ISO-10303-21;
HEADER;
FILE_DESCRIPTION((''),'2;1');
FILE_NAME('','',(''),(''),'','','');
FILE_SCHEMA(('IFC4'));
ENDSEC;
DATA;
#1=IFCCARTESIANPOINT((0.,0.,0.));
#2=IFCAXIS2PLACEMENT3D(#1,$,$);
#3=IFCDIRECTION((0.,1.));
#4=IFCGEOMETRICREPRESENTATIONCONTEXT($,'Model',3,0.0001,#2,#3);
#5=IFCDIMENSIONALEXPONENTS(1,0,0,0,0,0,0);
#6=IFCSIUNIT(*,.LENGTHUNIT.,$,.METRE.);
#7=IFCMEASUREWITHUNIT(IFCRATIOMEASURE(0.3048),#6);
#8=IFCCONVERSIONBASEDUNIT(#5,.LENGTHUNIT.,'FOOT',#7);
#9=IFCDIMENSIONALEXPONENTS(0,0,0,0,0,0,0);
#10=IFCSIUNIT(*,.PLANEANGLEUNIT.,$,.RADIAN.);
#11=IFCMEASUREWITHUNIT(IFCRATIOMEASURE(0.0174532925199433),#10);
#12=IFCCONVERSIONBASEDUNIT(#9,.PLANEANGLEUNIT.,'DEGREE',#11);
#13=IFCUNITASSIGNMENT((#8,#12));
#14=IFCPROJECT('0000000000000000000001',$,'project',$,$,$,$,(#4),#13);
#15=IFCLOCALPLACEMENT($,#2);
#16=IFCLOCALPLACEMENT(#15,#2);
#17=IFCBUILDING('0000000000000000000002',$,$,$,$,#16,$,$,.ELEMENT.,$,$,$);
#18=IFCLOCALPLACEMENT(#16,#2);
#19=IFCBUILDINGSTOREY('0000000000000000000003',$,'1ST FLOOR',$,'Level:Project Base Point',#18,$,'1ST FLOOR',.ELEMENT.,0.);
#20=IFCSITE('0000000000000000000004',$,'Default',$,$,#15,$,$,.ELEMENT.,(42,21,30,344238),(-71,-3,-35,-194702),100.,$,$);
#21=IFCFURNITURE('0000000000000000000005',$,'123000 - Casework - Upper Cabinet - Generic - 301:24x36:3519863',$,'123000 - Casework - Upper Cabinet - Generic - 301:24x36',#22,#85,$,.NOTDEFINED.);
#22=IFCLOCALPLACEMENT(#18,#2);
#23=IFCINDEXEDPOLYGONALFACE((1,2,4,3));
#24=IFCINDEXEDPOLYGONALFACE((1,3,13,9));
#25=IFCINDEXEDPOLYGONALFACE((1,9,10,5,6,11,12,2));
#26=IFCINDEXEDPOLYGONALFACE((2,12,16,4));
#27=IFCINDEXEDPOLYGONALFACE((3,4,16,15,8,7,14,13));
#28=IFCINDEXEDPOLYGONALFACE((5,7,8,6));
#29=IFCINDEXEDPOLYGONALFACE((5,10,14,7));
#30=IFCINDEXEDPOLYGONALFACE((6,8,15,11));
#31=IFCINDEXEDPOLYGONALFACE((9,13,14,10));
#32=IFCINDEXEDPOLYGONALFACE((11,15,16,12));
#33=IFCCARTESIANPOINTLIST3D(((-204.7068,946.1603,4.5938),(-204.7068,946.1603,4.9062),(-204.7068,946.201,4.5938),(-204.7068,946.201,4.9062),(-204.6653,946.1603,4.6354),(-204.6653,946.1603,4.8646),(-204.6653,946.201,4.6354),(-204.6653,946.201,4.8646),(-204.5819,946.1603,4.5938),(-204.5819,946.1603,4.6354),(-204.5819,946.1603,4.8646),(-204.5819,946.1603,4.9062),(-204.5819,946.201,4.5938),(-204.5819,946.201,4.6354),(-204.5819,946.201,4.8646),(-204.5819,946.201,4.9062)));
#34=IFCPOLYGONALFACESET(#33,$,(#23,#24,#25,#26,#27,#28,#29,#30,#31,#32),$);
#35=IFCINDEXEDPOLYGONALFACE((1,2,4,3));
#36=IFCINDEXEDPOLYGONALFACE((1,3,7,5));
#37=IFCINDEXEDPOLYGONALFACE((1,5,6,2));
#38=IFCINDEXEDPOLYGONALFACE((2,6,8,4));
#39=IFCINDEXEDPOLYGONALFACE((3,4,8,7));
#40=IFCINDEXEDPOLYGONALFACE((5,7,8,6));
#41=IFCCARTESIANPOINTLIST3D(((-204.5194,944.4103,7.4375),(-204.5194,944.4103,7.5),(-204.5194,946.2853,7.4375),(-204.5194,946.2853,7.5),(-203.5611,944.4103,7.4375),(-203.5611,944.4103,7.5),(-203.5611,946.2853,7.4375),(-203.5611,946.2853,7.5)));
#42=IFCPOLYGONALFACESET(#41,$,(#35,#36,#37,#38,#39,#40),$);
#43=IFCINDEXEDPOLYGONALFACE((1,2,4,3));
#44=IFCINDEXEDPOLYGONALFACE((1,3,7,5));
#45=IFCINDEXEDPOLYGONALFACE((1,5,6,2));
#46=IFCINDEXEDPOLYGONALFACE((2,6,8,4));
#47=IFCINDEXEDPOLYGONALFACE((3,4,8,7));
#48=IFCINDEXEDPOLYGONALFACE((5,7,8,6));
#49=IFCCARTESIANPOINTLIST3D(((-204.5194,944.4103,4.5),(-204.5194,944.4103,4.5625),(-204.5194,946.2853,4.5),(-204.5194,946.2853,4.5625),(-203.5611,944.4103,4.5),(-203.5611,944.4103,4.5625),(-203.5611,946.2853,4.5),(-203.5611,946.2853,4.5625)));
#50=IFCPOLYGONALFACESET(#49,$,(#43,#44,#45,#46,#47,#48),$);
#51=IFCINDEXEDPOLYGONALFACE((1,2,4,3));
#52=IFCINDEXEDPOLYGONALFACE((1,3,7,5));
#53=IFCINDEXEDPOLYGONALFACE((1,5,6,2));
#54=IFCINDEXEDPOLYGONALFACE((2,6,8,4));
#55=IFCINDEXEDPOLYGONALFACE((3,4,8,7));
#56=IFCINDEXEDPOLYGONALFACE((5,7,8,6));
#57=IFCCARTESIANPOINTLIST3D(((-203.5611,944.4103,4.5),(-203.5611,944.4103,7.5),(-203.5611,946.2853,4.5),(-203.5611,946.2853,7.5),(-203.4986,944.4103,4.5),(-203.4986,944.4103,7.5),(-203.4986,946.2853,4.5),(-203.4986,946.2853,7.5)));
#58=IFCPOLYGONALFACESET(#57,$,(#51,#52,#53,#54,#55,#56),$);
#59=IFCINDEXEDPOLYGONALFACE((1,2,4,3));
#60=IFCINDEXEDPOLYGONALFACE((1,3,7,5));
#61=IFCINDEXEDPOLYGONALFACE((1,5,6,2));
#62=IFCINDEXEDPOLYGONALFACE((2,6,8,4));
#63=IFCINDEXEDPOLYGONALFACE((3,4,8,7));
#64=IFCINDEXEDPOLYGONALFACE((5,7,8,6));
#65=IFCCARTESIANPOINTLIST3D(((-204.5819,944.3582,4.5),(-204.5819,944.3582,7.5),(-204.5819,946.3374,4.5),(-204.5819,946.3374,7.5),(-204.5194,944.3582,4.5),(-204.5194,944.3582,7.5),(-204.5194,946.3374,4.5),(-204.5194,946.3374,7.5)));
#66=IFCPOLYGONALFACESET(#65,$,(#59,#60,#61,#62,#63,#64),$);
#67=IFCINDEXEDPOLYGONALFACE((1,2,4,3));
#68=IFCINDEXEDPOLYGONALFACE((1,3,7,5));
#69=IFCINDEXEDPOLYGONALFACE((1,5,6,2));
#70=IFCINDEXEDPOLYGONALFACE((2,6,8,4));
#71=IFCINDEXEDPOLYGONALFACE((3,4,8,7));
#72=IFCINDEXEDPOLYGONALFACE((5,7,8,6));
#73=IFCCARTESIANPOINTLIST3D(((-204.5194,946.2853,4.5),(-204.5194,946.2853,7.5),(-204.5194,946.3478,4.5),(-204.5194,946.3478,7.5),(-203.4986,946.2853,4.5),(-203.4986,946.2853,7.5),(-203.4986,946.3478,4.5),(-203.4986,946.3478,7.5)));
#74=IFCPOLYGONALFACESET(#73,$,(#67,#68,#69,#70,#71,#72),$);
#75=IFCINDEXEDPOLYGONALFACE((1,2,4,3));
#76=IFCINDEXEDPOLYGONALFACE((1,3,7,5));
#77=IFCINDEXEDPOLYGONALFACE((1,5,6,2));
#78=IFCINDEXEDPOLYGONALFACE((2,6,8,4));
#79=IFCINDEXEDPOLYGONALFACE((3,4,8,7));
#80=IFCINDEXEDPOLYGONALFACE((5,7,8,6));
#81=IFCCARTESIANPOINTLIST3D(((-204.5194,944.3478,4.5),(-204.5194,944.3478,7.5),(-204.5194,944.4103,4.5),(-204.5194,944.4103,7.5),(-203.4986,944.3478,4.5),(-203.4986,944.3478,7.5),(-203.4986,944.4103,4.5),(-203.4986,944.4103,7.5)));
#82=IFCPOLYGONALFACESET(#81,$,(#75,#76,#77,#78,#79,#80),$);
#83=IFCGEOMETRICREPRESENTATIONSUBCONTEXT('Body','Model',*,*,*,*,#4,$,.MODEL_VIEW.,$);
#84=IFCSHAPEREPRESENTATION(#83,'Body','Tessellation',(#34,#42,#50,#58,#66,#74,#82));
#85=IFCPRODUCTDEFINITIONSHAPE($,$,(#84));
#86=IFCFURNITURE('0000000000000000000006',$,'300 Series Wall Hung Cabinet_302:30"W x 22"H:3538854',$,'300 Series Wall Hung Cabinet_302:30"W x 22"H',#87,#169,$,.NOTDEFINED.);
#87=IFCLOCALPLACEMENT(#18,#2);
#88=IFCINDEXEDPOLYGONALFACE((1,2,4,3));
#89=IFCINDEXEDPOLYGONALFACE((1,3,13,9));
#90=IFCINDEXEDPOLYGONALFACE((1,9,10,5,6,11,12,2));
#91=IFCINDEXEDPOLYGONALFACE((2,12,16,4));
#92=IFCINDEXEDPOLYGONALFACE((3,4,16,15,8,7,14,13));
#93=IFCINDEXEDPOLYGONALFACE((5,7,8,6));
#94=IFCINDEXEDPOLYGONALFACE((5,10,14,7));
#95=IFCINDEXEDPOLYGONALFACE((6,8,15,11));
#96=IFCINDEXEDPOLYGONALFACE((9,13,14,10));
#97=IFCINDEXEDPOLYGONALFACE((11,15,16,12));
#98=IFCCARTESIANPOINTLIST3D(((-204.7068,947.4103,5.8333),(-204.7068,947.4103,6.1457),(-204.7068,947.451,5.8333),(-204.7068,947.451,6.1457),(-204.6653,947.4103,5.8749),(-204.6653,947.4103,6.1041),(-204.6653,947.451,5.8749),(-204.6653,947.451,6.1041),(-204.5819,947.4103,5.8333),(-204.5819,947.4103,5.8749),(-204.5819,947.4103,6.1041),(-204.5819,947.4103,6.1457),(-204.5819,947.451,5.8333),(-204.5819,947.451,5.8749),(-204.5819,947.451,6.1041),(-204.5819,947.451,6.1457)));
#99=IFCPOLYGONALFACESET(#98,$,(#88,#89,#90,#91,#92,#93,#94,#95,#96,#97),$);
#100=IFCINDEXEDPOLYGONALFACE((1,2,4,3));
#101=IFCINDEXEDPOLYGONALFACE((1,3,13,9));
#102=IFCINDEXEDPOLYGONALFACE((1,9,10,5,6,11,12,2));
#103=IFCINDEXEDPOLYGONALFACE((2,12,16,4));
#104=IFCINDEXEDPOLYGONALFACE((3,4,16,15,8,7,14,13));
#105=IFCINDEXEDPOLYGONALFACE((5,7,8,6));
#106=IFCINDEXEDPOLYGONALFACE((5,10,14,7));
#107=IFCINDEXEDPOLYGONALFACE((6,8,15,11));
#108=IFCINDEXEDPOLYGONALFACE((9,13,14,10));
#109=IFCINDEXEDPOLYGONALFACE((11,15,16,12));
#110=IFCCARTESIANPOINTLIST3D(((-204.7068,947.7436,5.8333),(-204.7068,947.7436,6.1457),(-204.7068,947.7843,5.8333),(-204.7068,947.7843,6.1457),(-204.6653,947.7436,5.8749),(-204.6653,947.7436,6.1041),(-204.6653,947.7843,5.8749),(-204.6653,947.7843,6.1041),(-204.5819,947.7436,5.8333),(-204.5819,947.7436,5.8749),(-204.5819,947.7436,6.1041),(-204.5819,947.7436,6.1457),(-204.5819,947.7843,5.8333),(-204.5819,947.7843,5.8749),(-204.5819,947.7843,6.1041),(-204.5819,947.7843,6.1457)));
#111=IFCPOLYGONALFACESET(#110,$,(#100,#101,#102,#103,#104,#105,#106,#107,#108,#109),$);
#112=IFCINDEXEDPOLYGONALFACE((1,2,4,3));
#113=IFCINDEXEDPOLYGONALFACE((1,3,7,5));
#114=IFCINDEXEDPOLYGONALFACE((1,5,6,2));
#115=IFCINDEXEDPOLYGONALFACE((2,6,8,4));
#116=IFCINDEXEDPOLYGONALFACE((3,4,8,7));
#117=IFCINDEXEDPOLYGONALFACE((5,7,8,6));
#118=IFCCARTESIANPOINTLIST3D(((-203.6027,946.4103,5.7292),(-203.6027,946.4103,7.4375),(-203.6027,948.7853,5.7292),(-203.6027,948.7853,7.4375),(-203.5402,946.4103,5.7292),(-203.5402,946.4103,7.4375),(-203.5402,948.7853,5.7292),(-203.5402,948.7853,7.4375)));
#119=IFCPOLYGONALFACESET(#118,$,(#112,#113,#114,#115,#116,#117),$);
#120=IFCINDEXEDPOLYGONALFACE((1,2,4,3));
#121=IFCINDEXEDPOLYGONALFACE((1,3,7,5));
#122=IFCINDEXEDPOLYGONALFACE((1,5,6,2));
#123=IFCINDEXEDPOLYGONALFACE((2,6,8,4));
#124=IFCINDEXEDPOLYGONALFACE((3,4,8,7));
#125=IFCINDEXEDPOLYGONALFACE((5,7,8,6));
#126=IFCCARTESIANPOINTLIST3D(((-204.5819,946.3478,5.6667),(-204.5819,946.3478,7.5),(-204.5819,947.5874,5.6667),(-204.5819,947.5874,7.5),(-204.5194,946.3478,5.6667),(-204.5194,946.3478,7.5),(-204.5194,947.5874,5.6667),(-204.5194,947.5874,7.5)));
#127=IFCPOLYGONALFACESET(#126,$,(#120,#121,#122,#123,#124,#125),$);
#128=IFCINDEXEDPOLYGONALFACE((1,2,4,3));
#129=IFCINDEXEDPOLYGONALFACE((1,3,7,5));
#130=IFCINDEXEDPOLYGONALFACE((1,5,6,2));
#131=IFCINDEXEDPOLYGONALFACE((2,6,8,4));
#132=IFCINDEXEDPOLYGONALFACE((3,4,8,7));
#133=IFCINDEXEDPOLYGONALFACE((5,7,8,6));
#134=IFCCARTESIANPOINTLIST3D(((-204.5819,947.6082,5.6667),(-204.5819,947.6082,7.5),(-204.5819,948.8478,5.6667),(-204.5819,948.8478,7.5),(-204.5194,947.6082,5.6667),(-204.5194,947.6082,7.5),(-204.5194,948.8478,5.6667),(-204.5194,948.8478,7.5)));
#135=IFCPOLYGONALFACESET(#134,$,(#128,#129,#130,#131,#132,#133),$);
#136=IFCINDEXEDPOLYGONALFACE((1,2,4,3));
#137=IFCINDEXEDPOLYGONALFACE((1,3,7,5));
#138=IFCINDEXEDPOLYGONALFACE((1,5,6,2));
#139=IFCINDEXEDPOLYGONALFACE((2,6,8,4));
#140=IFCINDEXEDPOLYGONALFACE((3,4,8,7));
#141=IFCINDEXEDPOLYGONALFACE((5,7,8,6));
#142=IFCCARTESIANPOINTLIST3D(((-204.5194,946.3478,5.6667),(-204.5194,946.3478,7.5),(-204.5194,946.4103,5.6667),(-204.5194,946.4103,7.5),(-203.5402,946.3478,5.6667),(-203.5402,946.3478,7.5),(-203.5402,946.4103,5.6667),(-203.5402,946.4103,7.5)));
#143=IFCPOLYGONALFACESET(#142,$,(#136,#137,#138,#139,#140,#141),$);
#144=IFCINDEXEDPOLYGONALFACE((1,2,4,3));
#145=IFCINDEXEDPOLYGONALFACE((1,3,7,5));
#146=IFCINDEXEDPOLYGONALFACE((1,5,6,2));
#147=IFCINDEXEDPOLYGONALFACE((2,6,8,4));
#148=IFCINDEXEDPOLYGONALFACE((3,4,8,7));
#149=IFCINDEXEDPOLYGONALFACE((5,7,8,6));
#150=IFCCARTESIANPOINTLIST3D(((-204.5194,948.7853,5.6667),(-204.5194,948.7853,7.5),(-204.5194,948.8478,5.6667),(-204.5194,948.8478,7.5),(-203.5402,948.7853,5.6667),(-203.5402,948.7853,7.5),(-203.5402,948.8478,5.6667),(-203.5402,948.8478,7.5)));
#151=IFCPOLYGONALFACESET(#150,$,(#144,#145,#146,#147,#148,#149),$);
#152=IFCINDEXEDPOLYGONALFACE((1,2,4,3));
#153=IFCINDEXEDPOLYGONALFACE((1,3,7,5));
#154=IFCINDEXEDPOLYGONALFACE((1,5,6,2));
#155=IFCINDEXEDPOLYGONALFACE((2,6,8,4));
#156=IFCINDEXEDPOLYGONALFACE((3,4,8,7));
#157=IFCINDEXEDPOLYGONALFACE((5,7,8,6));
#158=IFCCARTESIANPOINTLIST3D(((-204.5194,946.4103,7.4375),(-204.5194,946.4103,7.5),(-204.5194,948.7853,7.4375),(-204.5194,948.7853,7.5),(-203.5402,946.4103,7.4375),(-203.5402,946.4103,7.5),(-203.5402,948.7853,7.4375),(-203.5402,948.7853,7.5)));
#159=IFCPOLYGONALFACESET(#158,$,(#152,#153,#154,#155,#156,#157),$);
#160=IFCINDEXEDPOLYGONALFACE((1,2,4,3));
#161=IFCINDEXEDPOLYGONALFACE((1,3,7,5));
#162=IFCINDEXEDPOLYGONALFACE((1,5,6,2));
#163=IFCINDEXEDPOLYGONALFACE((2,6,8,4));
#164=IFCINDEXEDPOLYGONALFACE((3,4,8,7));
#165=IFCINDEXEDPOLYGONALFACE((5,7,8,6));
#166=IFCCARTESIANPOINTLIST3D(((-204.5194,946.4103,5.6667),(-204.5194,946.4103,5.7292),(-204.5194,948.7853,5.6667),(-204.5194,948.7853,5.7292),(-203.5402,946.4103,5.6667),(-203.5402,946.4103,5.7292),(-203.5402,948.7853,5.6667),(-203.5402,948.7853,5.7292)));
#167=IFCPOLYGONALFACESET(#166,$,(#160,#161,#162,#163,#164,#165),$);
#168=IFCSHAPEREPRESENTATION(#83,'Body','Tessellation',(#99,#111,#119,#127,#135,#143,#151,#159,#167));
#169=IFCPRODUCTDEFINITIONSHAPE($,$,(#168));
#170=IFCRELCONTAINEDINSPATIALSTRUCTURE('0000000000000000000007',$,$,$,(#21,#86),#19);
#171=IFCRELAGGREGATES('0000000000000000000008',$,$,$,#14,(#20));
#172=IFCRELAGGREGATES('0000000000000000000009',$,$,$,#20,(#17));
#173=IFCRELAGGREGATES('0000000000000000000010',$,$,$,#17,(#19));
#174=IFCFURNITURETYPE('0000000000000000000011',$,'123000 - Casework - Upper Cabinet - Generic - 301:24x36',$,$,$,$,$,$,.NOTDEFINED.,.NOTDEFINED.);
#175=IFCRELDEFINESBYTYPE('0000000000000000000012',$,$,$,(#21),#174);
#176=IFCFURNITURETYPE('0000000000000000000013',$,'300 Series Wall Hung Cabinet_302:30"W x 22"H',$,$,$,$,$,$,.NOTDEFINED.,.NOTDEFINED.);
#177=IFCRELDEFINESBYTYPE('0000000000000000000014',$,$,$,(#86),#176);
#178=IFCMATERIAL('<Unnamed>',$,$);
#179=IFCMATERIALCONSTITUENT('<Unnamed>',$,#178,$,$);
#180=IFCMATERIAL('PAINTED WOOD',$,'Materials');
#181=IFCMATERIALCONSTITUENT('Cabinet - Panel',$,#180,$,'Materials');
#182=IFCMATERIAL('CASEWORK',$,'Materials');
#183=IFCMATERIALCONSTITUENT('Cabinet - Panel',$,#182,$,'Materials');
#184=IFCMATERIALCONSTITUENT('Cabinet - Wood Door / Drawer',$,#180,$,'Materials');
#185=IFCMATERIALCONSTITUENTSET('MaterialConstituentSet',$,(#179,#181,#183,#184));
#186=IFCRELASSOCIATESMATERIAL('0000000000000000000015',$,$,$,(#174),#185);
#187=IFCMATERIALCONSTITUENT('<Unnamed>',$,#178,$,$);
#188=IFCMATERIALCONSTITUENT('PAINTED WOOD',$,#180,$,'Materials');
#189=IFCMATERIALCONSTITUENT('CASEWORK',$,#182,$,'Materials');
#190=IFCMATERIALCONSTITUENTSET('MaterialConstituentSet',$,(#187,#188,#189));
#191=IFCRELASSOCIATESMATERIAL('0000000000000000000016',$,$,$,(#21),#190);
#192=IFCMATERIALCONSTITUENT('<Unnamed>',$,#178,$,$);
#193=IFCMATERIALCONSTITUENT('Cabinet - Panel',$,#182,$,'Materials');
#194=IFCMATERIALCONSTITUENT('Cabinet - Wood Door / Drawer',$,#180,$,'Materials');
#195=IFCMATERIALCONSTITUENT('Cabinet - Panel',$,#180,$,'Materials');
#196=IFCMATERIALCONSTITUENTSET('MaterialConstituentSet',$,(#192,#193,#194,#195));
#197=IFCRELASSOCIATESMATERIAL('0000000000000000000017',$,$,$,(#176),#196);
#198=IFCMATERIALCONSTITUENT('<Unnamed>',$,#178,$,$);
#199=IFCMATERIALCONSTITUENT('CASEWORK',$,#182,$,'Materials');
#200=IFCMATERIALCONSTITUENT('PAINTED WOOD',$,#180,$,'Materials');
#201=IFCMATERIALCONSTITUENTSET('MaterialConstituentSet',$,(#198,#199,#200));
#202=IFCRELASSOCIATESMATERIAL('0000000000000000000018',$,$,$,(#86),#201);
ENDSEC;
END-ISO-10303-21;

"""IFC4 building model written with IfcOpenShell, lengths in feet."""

from ifc_helpers import new_model, entity, si_unit, converted_unit, direction, frame, frame_2d, origin, origin_2d_with_axis, place, context, subcontext, project, spatial, polyline, rectangle, outline, extrude, source, transform, mapped, material, constituent, constituent_set, type_object, type_shapes, element, save


model = new_model("IFC4")

# Units and contexts
model_context = context("Model", 3, precision=0.0001, world=origin(), true_north=direction((0.0, 1.0)))
body_context = subcontext(model_context, "Body", "Model", "MODEL_VIEW")
ifc_project = project(units=[converted_unit("LENGTHUNIT", "FOOT", entity("IfcRatioMeasure", 0.3048), si_unit("LENGTHUNIT", "METRE"), dimensions=[1, 0, 0, 0, 0, 0, 0]), converted_unit("PLANEANGLEUNIT", "DEGREE", entity("IfcRatioMeasure", 0.0174532925199433), si_unit("PLANEANGLEUNIT", "RADIAN"), dimensions=[0, 0, 0, 0, 0, 0, 0])], contexts=[model_context])

# Site, building, storey
site_placement = place(None, origin())
site = spatial("IfcSite", under=ifc_project, at=site_placement, Name="Default", CompositionType="ELEMENT", RefLatitude=(42, 21, 30, 344238), RefLongitude=(-71, -3, -35, -194702), RefElevation=100.0)
building_placement = place(site_placement, origin())
building = spatial("IfcBuilding", under=site, at=building_placement, CompositionType="ELEMENT")
storey_placement = place(building_placement, origin())
storey = spatial("IfcBuildingStorey", under=building, at=storey_placement, Name="1ST FLOOR", ObjectType="Level:Project Base Point", LongName="1ST FLOOR", CompositionType="ELEMENT", Elevation=0.0)

# Furniture
ifc_material_1 = material(Name="PAINTED WOOD", Category="Materials")
ifc_material_2 = material(Name="CASEWORK", Category="Materials")
ifc_material_3 = material(Name="<Unnamed>")
ifc_constituent_1 = constituent(ifc_material_3, Name="<Unnamed>")
ifc_constituent_2 = constituent(ifc_material_1, Name="PAINTED WOOD", Category="Materials")
ifc_constituent_3 = constituent(ifc_material_2, Name="CASEWORK", Category="Materials")
ifc_constituent_set_1 = constituent_set(constituents=[ifc_constituent_1, ifc_constituent_2, ifc_constituent_3], Name="MaterialConstituentSet")
ifc_constituent_4 = constituent(ifc_material_3, Name="<Unnamed>")
ifc_constituent_5 = constituent(ifc_material_1, Name="Cabinet - Panel", Category="Materials")
ifc_constituent_6 = constituent(ifc_material_2, Name="Cabinet - Panel", Category="Materials")
ifc_constituent_7 = constituent(ifc_material_1, Name="Cabinet - Wood Door / Drawer", Category="Materials")
ifc_constituent_set_2 = constituent_set(constituents=[ifc_constituent_4, ifc_constituent_5, ifc_constituent_6, ifc_constituent_7], Name="MaterialConstituentSet")
furniture_type_1 = type_object("IfcFurnitureType", Name="123000 - Casework - Upper Cabinet - Generic - 301:24x36", AssemblyPlace="NOTDEFINED", PredefinedType="NOTDEFINED", material=ifc_constituent_set_2)
shared_shape_1 = source(origin(), body_context, "Body", "SweptSolid", [
    extrude(outline(polyline([(0.1146, -0.0521), (0.1562, -0.0521), (0.1562, 0.0729), (-0.1562, 0.0729), (-0.1562, -0.0521), (-0.1146, -0.0521), (-0.1146, 0.0313), (0.1146, 0.0313), (0.1146, -0.0521)])), frame((0.1468, 0.0729, 0.25), z_axis=(1.0, 0.0, 0.0), x_axis=(0.0, 0.0, 1.0)), (0.0, 0.0, 1.0), 0.0407),
    extrude(rectangle(XDim=1.875, YDim=0.9583, at=frame_2d((0.0, 0.0), x_axis=(1.0, 0.0))), frame((1.0, 0.6666, 2.9375), z_axis=(0.0, 0.0, 1.0), x_axis=(-1.0, 0.0, 0.0)), (0.0, 0.0, 1.0), 0.0625),
    extrude(rectangle(XDim=1.875, YDim=0.9583, at=frame_2d((0.0, 0.0), x_axis=(1.0, 0.0))), frame((1.0, 0.6666, 0.0), z_axis=(0.0, 0.0, 1.0), x_axis=(-1.0, 0.0, 0.0)), (0.0, 0.0, 1.0), 0.0625),
    extrude(rectangle(XDim=0.0625, YDim=1.875, at=origin_2d_with_axis()), frame((1.0, 1.177, 0.0), z_axis=(0.0, 0.0, 1.0), x_axis=(0.0, 1.0, 0.0)), (0.0, 0.0, 1.0), 3.0),
    extrude(rectangle(XDim=0.0625, YDim=1.9792, at=frame_2d((0.0, 0.0), x_axis=(1.0, 0.0))), frame((1.0, 0.1562, 0.0), z_axis=(0.0, 0.0, 1.0), x_axis=(0.0, -1.0, 0.0)), (0.0, 0.0, 1.0), 3.0),
    extrude(rectangle(XDim=0.0625, YDim=1.0208, at=origin_2d_with_axis()), frame((0.0312, 0.6979, 0.0), z_axis=(0.0, 0.0, 1.0), x_axis=(-1.0, 0.0, 0.0)), (0.0, 0.0, 1.0), 3.0),
    extrude(rectangle(XDim=0.0625, YDim=1.0208, at=origin_2d_with_axis()), frame((1.9688, 0.6979, 0.0), z_axis=(0.0, 0.0, 1.0), x_axis=(-1.0, 0.0, 0.0)), (0.0, 0.0, 1.0), 3.0),
])
type_shapes(furniture_type_1, [shared_shape_1])
furniture_1_placement = place(storey_placement, frame((-204.7068, 946.3478, 4.5), z_axis=(0.0, 0.0, 1.0), x_axis=(0.0, -1.0, 0.0)))
element("IfcFurniture", 1, at=furniture_1_placement, inside=storey, type_object=furniture_type_1, material=ifc_constituent_set_1, Name="123000 - Casework - Upper Cabinet - Generic - 301:24x36:3519863", ObjectType="123000 - Casework - Upper Cabinet - Generic - 301:24x36", PredefinedType="NOTDEFINED", context=body_context, shape_type="MappedRepresentation", body=[
    mapped(shared_shape_1, transform((0.0, 0.0, 0.0), scale=1.0)),
])
ifc_constituent_8 = constituent(ifc_material_3, Name="<Unnamed>")
ifc_constituent_9 = constituent(ifc_material_2, Name="CASEWORK", Category="Materials")
ifc_constituent_10 = constituent(ifc_material_1, Name="PAINTED WOOD", Category="Materials")
ifc_constituent_set_3 = constituent_set(constituents=[ifc_constituent_8, ifc_constituent_9, ifc_constituent_10], Name="MaterialConstituentSet")
ifc_constituent_11 = constituent(ifc_material_3, Name="<Unnamed>")
ifc_constituent_12 = constituent(ifc_material_2, Name="Cabinet - Panel", Category="Materials")
ifc_constituent_13 = constituent(ifc_material_1, Name="Cabinet - Wood Door / Drawer", Category="Materials")
ifc_constituent_14 = constituent(ifc_material_1, Name="Cabinet - Panel", Category="Materials")
ifc_constituent_set_4 = constituent_set(constituents=[ifc_constituent_11, ifc_constituent_12, ifc_constituent_13, ifc_constituent_14], Name="MaterialConstituentSet")
furniture_type_2 = type_object("IfcFurnitureType", Name="300 Series Wall Hung Cabinet_302:30\"W x 22\"H", AssemblyPlace="NOTDEFINED", PredefinedType="NOTDEFINED", material=ifc_constituent_set_4)
shared_shape_2 = source(origin(), body_context, "Body", "SweptSolid", [
    extrude(outline(polyline([(-0.0521, -0.1146), (-0.0521, -0.1562), (0.0729, -0.1562), (0.0729, 0.1562), (-0.0521, 0.1562), (-0.0521, 0.1146), (0.0313, 0.1146), (0.0313, -0.1146), (-0.0521, -0.1146)])), frame((1.0625, 1.0937, 0.3229), z_axis=(-1.0, 0.0, 0.0), x_axis=(0.0, 1.0, 0.0)), (0.0, 0.0, -1.0), 0.0407),
    extrude(outline(polyline([(-0.0521, -0.1146), (-0.0521, -0.1562), (0.0729, -0.1562), (0.0729, 0.1562), (-0.0521, 0.1562), (-0.0521, 0.1146), (0.0313, 0.1146), (0.0313, -0.1146), (-0.0521, -0.1146)])), frame((1.3958, 1.0937, 0.3229), z_axis=(-1.0, 0.0, 0.0), x_axis=(0.0, 1.0, 0.0)), (0.0, 0.0, -1.0), 0.0407),
    extrude(rectangle(XDim=0.0625, YDim=2.375, at=frame_2d((0.0, 0.0), x_axis=(1.0, 0.0))), frame((1.25, 0.0313, 0.0625), z_axis=(0.0, 0.0, 1.0), x_axis=(0.0, 1.0, 0.0)), (0.0, 0.0, 1.0), 1.7083),
    extrude(rectangle(XDim=0.0625, YDim=1.2396, at=origin_2d_with_axis()), frame((0.6198, 1.0104, 0.0), z_axis=(0.0, 0.0, 1.0), x_axis=(0.0, 1.0, 0.0)), (0.0, 0.0, 1.0), 1.8333),
    extrude(rectangle(XDim=0.0625, YDim=1.2396, at=frame_2d((0.0, 0.0), x_axis=(1.0, 0.0))), frame((1.8802, 1.0104, 0.0), z_axis=(0.0, 0.0, 1.0), x_axis=(0.0, 1.0, 0.0)), (0.0, 0.0, 1.0), 1.8333),
    extrude(rectangle(XDim=0.0625, YDim=0.9792, at=frame_2d((0.0, 0.0), x_axis=(1.0, 0.0))), frame((0.0313, 0.4896, 0.0)), (0.0, 0.0, 1.0), 1.8333),
    extrude(rectangle(XDim=0.0625, YDim=0.9792, at=frame_2d((0.0, 0.0), x_axis=(1.0, 0.0))), frame((2.4688, 0.4896, 0.0)), (0.0, 0.0, 1.0), 1.8333),
    extrude(rectangle(XDim=2.375, YDim=0.9792, at=frame_2d((0.0, 0.0), x_axis=(1.0, 0.0))), frame((1.25, 0.4896, 1.7708), z_axis=(0.0, 0.0, 1.0), x_axis=(-1.0, 0.0, 0.0)), (0.0, 0.0, 1.0), 0.0625),
    extrude(rectangle(XDim=2.375, YDim=0.9792, at=frame_2d((0.0, 0.0), x_axis=(1.0, 0.0))), frame((1.25, 0.4896, 0.0), z_axis=(0.0, 0.0, 1.0), x_axis=(-1.0, 0.0, 0.0)), (0.0, 0.0, 1.0), 0.0625),
])
type_shapes(furniture_type_2, [shared_shape_2])
furniture_2_placement = place(storey_placement, frame((-203.5402, 946.3478, 5.6667), z_axis=(0.0, 0.0, 1.0), x_axis=(0.0, 1.0, 0.0)))
element("IfcFurniture", 2, at=furniture_2_placement, inside=storey, type_object=furniture_type_2, material=ifc_constituent_set_3, Name="300 Series Wall Hung Cabinet_302:30\"W x 22\"H:3538854", ObjectType="300 Series Wall Hung Cabinet_302:30\"W x 22\"H", PredefinedType="NOTDEFINED", context=body_context, shape_type="MappedRepresentation", body=[
    mapped(shared_shape_2, transform((0.0, 0.0, 0.0), scale=1.0)),
])

save(model, "model.ifc")
